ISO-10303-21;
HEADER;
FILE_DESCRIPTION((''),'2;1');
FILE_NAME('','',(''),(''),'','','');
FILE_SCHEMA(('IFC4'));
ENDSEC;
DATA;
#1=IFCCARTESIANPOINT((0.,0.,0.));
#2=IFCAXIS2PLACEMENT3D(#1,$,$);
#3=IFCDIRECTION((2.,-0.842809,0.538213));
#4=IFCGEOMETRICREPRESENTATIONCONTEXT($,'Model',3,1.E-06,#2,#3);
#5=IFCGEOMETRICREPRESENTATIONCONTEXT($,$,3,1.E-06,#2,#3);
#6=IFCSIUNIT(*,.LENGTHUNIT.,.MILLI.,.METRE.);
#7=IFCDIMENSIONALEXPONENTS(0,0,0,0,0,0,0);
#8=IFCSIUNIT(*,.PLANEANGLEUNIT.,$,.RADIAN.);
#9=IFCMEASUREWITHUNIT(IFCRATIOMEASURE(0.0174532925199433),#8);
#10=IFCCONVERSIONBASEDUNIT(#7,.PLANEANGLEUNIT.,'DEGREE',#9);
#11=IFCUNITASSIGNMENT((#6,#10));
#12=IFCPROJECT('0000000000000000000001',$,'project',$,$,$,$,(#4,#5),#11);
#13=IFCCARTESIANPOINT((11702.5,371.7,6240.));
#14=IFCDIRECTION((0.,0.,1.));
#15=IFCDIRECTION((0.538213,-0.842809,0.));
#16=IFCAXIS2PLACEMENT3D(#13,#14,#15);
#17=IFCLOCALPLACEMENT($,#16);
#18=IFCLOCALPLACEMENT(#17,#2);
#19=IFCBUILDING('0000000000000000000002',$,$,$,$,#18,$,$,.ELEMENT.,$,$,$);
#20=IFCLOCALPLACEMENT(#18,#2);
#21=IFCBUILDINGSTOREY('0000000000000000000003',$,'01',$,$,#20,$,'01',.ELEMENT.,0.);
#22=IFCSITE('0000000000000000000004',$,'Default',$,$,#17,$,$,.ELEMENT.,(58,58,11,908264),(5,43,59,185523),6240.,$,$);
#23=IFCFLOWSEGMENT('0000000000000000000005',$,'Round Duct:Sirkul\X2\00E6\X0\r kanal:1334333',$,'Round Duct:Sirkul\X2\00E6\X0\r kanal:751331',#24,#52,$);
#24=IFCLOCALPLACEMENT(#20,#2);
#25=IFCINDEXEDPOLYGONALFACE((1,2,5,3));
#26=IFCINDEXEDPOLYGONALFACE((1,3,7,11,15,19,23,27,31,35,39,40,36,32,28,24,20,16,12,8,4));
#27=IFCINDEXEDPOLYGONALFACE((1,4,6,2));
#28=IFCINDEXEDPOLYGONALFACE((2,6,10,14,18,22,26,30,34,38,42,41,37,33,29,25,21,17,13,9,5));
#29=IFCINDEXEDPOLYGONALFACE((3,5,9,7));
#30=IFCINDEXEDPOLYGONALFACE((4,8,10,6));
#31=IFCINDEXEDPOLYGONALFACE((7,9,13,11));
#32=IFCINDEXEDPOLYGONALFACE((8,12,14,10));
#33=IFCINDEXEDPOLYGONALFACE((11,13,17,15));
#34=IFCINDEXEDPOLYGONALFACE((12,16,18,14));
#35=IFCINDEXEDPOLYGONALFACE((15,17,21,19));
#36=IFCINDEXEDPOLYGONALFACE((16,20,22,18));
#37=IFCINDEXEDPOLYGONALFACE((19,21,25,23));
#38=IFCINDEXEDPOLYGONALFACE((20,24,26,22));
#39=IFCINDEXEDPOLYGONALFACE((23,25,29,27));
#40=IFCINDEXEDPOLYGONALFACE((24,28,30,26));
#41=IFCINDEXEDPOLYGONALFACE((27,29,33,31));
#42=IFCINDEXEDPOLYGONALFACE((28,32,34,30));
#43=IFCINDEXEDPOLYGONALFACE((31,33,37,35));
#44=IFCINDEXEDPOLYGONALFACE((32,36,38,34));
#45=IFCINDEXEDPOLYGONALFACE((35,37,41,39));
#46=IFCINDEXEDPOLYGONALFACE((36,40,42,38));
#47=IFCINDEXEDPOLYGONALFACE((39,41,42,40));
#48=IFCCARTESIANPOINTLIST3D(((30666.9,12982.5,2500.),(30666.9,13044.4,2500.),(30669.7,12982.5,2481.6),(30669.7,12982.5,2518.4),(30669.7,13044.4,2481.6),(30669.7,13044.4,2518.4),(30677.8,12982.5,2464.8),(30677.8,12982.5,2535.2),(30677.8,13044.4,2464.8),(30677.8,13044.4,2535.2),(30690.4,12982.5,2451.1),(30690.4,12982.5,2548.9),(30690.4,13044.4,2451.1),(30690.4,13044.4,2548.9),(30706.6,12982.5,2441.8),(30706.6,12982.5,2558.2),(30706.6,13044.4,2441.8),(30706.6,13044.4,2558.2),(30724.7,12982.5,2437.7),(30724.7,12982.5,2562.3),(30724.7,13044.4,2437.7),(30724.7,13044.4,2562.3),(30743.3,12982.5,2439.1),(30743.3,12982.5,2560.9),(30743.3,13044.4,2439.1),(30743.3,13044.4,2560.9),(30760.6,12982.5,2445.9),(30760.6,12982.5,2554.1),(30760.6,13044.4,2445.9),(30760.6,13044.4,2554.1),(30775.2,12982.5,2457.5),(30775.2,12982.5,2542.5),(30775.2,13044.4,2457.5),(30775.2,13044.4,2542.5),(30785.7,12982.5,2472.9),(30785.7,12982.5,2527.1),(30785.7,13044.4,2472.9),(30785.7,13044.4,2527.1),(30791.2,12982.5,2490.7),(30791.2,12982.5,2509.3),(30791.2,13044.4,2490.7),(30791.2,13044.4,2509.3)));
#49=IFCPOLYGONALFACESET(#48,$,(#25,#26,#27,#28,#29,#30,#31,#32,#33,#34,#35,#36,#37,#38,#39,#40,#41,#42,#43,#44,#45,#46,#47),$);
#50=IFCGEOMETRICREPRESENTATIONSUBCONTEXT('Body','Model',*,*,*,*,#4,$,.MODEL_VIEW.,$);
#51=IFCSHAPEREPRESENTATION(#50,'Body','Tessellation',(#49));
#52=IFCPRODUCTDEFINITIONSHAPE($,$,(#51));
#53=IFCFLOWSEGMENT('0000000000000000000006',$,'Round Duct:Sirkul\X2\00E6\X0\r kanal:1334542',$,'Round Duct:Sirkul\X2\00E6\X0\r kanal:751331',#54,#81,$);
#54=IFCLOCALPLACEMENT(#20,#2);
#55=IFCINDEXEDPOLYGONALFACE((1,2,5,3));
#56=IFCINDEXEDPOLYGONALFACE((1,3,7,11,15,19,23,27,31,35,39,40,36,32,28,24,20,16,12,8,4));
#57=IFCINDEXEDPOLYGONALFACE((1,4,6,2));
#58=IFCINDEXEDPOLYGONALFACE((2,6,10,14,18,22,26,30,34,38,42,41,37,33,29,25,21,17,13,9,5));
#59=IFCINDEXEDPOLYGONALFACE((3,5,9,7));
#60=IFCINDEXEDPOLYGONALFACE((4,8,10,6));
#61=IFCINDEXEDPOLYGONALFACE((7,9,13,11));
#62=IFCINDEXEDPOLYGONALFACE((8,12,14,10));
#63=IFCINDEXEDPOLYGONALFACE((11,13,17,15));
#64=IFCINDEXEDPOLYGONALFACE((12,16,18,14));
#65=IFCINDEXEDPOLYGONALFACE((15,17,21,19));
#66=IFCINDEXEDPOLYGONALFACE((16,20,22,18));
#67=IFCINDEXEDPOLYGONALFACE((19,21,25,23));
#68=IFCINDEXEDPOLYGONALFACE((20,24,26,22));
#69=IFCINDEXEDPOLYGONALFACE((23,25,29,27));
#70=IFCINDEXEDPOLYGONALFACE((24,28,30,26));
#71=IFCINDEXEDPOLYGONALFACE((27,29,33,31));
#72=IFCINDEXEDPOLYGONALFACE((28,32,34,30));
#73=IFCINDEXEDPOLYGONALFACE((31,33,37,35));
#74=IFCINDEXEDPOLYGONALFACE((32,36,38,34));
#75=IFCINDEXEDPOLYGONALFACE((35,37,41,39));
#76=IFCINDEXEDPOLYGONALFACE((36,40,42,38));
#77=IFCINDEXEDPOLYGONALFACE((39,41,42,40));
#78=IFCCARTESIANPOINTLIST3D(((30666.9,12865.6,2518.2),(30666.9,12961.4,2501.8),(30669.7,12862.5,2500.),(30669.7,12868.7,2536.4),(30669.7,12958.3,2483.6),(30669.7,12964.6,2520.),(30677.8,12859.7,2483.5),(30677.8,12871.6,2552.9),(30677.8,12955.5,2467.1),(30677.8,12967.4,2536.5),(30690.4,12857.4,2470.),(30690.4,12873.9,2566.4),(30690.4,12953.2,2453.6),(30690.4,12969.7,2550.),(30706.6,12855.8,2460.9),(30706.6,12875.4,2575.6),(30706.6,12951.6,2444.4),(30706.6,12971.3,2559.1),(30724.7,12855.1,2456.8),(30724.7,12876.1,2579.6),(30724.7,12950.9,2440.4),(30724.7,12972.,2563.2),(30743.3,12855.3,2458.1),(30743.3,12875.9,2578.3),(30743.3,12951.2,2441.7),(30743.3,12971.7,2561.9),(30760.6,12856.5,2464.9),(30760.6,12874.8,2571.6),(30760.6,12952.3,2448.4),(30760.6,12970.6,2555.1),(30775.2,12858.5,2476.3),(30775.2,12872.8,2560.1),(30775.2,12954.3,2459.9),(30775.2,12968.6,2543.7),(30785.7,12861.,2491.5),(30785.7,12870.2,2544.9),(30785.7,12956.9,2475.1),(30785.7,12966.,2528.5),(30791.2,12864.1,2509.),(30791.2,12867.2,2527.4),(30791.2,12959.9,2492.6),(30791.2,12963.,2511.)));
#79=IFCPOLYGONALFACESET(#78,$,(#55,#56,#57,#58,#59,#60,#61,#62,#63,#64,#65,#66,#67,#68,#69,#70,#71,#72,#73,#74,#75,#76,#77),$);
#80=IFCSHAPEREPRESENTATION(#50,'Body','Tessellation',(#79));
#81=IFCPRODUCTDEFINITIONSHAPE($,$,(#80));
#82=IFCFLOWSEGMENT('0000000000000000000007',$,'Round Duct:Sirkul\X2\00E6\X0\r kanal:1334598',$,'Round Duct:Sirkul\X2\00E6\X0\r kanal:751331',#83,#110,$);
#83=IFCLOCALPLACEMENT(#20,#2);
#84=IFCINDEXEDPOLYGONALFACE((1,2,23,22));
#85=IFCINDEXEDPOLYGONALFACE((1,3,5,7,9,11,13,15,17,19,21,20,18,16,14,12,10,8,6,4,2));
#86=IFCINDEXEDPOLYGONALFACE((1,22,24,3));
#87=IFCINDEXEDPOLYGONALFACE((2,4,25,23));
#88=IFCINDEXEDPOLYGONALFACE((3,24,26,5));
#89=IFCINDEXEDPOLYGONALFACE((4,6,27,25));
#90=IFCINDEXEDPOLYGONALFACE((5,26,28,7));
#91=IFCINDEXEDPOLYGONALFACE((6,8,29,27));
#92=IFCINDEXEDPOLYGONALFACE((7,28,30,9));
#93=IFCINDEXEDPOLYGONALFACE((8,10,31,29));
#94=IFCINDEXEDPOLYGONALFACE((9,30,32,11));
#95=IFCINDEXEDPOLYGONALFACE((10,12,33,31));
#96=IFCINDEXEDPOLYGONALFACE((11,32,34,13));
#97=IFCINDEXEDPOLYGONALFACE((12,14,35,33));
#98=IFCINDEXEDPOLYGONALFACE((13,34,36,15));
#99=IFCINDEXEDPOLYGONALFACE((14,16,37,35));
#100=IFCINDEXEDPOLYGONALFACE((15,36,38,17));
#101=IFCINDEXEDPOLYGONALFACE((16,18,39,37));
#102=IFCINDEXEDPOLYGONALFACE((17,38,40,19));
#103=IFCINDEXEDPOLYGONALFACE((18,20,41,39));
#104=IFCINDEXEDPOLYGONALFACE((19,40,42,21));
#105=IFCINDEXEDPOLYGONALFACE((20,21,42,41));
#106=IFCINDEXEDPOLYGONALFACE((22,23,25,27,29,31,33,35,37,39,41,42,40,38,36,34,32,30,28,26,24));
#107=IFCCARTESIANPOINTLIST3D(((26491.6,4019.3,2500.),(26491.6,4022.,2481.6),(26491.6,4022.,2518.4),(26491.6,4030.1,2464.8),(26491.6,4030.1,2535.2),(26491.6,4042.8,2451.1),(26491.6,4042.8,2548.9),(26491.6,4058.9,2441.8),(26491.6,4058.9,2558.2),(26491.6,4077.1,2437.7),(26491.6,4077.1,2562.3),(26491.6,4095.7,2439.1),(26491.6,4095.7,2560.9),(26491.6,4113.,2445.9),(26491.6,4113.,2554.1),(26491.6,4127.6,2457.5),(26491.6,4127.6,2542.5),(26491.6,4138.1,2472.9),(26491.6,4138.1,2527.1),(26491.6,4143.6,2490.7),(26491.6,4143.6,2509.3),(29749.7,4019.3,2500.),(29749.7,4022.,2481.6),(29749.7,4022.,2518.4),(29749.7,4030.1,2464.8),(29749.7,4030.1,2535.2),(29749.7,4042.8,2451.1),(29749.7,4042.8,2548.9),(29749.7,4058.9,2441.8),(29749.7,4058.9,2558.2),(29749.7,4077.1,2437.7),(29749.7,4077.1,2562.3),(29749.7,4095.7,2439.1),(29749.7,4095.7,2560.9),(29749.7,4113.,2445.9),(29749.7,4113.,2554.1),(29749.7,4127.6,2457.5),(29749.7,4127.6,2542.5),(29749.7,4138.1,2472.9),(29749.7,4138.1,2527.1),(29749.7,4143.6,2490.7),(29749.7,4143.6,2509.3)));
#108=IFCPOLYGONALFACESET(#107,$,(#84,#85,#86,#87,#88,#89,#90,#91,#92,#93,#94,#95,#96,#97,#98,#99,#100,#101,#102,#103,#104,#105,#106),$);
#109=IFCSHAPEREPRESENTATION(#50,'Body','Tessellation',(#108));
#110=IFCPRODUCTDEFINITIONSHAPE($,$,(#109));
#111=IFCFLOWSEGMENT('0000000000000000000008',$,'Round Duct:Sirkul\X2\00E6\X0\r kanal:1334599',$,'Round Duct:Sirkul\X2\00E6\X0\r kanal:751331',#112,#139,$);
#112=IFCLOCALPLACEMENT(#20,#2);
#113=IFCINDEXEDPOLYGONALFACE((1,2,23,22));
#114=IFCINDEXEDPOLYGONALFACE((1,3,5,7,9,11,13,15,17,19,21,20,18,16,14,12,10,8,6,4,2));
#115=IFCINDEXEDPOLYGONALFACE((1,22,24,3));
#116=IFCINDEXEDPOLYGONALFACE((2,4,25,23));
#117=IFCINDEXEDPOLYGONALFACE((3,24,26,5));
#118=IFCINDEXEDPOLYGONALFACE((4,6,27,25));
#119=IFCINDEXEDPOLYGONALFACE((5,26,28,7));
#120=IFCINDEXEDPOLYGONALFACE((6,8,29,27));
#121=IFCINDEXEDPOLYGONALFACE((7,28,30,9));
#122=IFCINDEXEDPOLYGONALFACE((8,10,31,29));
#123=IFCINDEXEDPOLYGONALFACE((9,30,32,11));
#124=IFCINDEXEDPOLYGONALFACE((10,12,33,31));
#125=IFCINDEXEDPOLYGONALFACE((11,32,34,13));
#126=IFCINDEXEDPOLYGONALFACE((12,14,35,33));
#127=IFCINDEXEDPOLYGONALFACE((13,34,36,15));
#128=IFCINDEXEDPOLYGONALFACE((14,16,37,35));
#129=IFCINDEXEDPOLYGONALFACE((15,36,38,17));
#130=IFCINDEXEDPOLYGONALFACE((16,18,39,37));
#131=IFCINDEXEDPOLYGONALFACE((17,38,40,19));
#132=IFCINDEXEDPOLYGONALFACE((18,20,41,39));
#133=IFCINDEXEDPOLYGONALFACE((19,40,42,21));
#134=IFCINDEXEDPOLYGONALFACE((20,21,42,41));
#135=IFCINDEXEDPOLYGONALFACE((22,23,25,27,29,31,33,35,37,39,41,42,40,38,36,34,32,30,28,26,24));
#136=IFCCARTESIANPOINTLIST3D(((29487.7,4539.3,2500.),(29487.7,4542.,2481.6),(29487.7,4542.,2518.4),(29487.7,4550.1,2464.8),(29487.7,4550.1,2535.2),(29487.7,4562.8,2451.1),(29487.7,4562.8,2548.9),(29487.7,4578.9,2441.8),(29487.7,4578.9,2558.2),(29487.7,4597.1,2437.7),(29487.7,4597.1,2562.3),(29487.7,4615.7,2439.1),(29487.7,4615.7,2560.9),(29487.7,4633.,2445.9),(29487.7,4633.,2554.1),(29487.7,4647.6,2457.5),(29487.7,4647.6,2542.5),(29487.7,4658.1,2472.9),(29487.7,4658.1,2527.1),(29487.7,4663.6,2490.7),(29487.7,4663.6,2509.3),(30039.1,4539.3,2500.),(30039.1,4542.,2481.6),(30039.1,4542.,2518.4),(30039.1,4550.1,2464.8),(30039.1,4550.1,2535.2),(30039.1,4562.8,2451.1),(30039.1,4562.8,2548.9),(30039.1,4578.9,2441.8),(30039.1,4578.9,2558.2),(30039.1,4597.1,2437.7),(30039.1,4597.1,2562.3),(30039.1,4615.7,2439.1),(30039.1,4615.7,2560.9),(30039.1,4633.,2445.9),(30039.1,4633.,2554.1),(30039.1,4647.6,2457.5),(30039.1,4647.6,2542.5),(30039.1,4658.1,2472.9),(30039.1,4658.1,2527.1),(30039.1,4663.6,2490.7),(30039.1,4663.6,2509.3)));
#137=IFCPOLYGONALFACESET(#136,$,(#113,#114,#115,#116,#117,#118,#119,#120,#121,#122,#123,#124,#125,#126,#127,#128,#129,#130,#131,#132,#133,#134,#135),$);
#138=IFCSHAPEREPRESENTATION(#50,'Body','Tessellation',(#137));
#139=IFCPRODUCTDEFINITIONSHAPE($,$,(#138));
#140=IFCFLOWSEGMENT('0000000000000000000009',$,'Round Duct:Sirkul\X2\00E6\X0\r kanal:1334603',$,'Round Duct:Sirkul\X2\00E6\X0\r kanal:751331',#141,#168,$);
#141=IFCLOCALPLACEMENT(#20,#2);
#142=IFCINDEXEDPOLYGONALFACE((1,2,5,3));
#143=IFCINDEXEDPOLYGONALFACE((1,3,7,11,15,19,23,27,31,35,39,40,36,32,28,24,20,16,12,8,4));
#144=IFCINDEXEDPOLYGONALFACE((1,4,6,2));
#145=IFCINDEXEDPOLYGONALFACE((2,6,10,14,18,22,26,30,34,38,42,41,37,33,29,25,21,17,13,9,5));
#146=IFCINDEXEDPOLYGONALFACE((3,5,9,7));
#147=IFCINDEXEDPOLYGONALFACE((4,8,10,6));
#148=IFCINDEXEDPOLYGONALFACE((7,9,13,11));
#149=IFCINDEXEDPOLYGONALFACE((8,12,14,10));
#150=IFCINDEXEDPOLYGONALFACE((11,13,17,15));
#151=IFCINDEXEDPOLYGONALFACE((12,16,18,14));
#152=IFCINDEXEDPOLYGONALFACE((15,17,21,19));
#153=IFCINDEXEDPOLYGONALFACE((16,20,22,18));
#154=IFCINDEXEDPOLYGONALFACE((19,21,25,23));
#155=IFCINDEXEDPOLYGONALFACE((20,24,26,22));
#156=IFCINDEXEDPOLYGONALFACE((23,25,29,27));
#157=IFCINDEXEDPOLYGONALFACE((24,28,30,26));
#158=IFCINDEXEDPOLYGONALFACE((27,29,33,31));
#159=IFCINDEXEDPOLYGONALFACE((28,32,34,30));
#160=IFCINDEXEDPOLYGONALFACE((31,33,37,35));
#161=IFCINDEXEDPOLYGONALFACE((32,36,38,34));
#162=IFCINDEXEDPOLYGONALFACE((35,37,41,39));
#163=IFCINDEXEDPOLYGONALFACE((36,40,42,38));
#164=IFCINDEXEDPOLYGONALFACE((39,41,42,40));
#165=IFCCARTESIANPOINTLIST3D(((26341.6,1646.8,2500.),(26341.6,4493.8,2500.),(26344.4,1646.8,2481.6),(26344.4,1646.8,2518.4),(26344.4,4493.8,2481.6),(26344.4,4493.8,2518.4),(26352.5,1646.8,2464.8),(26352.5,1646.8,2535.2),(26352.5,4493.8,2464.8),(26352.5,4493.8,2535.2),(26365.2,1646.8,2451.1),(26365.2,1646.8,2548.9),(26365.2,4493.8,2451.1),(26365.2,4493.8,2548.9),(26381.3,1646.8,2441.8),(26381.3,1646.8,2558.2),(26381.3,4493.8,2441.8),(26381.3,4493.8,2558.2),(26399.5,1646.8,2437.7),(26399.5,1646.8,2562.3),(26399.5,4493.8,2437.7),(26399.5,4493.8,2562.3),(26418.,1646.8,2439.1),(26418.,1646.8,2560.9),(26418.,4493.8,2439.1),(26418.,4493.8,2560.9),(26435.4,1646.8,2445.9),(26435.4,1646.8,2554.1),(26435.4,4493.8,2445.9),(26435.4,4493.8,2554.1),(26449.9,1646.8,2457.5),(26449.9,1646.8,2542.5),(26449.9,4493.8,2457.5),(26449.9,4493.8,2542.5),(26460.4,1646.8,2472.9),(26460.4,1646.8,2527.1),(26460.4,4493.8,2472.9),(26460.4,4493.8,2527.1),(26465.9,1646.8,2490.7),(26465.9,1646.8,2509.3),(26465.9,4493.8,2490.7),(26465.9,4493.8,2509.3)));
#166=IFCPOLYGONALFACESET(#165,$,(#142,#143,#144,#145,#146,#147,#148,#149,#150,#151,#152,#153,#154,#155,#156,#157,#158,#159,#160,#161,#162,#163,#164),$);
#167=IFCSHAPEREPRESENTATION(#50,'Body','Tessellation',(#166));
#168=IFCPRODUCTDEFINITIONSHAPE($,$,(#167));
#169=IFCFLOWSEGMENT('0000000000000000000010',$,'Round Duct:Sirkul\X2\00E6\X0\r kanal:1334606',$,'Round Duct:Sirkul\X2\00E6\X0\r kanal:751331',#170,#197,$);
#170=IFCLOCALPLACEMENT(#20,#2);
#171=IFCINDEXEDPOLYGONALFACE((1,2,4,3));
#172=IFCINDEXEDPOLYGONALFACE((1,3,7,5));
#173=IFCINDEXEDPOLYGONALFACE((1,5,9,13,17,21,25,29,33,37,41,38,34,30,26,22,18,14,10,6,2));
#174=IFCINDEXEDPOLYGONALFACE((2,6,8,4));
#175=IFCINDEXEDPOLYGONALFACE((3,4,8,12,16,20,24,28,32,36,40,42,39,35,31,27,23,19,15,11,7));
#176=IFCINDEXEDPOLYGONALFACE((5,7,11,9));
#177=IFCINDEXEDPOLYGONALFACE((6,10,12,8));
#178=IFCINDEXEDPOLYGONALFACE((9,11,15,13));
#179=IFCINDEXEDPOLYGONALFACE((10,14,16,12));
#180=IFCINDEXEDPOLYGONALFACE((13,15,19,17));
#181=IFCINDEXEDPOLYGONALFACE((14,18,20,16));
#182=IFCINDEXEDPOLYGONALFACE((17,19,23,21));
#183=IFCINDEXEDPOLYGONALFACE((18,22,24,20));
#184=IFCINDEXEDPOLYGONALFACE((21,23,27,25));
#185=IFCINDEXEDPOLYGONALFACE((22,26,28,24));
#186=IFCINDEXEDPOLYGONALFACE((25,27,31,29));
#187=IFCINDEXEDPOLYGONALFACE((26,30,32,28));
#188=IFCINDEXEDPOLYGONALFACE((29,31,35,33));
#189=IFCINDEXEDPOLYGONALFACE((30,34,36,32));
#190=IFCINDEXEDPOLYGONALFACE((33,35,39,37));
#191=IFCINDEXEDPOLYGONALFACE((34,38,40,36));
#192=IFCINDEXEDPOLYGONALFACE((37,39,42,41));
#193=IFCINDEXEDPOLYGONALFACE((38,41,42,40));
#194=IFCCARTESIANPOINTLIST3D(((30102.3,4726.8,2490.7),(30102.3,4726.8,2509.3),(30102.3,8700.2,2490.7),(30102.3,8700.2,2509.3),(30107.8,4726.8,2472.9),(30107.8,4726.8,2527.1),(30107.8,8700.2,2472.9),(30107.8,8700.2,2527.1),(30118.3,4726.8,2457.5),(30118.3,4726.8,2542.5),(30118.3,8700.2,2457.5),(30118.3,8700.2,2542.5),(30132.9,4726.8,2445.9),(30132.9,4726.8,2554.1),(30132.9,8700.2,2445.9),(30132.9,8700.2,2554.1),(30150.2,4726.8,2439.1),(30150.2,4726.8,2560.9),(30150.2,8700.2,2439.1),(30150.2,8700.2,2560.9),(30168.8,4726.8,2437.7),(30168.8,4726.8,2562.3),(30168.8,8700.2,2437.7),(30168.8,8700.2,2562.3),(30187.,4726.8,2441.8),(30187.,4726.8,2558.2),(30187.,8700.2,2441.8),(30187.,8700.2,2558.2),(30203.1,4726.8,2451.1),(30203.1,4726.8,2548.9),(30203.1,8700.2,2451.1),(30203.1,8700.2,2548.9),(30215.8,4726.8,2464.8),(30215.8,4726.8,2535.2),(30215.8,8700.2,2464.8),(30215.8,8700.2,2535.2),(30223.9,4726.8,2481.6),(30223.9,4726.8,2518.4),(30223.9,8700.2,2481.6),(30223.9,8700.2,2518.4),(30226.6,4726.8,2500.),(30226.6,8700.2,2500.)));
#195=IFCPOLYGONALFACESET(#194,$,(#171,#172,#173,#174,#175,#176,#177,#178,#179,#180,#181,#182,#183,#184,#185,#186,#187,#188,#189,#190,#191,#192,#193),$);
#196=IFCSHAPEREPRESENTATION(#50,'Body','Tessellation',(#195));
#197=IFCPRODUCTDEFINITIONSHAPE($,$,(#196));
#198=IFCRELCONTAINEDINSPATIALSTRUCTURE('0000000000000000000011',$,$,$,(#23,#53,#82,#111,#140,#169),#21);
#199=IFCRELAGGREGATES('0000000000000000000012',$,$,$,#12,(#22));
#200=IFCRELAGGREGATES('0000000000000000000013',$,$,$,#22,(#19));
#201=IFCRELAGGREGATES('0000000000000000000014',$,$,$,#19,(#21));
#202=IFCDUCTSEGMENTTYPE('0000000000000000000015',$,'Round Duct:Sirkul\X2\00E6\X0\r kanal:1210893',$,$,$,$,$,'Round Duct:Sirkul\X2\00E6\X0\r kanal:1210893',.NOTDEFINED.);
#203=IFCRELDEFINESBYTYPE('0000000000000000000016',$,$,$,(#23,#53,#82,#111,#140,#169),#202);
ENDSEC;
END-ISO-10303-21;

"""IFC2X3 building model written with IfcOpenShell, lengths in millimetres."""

from ifc_helpers import new_model, entity, si_unit, converted_unit, direction, frame, frame_2d, origin, origin_2d_with_axis, place, context, subcontext, project, spatial, circle, extrude, type_object, element, save


model = new_model("IFC2X3")

# Units and contexts
model_context = context("Model", 3, precision=1e-06, world=origin(), true_north=direction((2.0, -0.842809, 0.538213)))
context_of_model = context(None, 3, precision=1e-06, world=origin(), true_north=direction((2.0, -0.842809, 0.538213)))
body_context = subcontext(model_context, "Body", "Model", "MODEL_VIEW")
ifc_project = project(units=[si_unit("LENGTHUNIT", "METRE", prefix="MILLI"), converted_unit("PLANEANGLEUNIT", "DEGREE", entity("IfcRatioMeasure", 0.0174532925199433), si_unit("PLANEANGLEUNIT", "RADIAN"), dimensions=[0, 0, 0, 0, 0, 0, 0])], contexts=[model_context, context_of_model])

# Site, building, storey
site_placement = place(None, frame((11702.5, 371.7, 6240.0), z_axis=(0.0, 0.0, 1.0), x_axis=(0.538213, -0.842809, 0.0)))
site = spatial("IfcSite", under=ifc_project, at=site_placement, Name="Default", CompositionType="ELEMENT", RefLatitude=(58, 58, 11, 908264), RefLongitude=(5, 43, 59, 185523), RefElevation=6240.0)
building_placement = place(site_placement, origin())
building = spatial("IfcBuilding", under=site, at=building_placement, CompositionType="ELEMENT")
storey_placement = place(building_placement, origin())
storey = spatial("IfcBuildingStorey", under=building, at=storey_placement, Name="01", LongName="01", CompositionType="ELEMENT", Elevation=0.0)

# Flow segments
duct_segment_type = type_object("IfcDuctSegmentType", Name="Round Duct:Sirkulær kanal:1210893", ElementType="Round Duct:Sirkulær kanal:1210893", PredefinedType="NOTDEFINED")
flow_segment_1_placement = place(storey_placement, origin())
element("IfcFlowSegment", 1, at=flow_segment_1_placement, inside=storey, type_object=duct_segment_type, Name="Round Duct:Sirkulær kanal:1334333", ObjectType="Round Duct:Sirkulær kanal:751331", context=body_context, shape_type="SweptSolid", body=[
    extrude(circle(Radius=62.5, at=frame_2d((0.0, 0.0), x_axis=(1.0, 0.0))), frame((30729.4, 12982.5, 2500.0), z_axis=(0.0, 1.0, 0.0), x_axis=(-1.0, 0.0, 0.0)), (0.0, 0.0, 1.0), 61.9),
])
flow_segment_2_placement = place(storey_placement, origin())
element("IfcFlowSegment", 2, at=flow_segment_2_placement, inside=storey, type_object=duct_segment_type, Name="Round Duct:Sirkulær kanal:1334542", ObjectType="Round Duct:Sirkulær kanal:751331", context=body_context, shape_type="SweptSolid", body=[
    extrude(circle(Radius=62.5, at=frame_2d((0.0, 0.0), x_axis=(1.0, 0.0))), frame((30729.4, 12961.4, 2501.8), z_axis=(0.0, -0.985646, 0.168824), x_axis=(-1.0, 0.0, 0.0)), (0.0, 0.0, 1.0), 97.2),
])
flow_segment_3_placement = place(storey_placement, origin())
element("IfcFlowSegment", 3, at=flow_segment_3_placement, inside=storey, type_object=duct_segment_type, Name="Round Duct:Sirkulær kanal:1334598", ObjectType="Round Duct:Sirkulær kanal:751331", context=body_context, shape_type="SweptSolid", body=[
    extrude(circle(Radius=62.5, at=origin_2d_with_axis()), frame((26491.6, 4081.8, 2500.0), z_axis=(1.0, 0.0, 0.0), x_axis=(0.0, -1.0, 0.0)), (0.0, 0.0, 1.0), 3258.0),
])
flow_segment_4_placement = place(storey_placement, origin())
element("IfcFlowSegment", 4, at=flow_segment_4_placement, inside=storey, type_object=duct_segment_type, Name="Round Duct:Sirkulær kanal:1334599", ObjectType="Round Duct:Sirkulær kanal:751331", context=body_context, shape_type="SweptSolid", body=[
    extrude(circle(Radius=62.5, at=origin_2d_with_axis()), frame((29487.7, 4601.8, 2500.0), z_axis=(1.0, 0.0, 0.0), x_axis=(0.0, -1.0, 0.0)), (0.0, 0.0, 1.0), 551.4),
])
flow_segment_5_placement = place(storey_placement, origin())
element("IfcFlowSegment", 5, at=flow_segment_5_placement, inside=storey, type_object=duct_segment_type, Name="Round Duct:Sirkulær kanal:1334603", ObjectType="Round Duct:Sirkulær kanal:751331", context=body_context, shape_type="SweptSolid", body=[
    extrude(circle(Radius=62.5, at=origin_2d_with_axis()), frame((26404.1, 1646.8, 2500.0), z_axis=(0.0, 1.0, 0.0), x_axis=(-1.0, 0.0, 0.0)), (0.0, 0.0, 1.0), 2847.0),
])
flow_segment_6_placement = place(storey_placement, origin())
element("IfcFlowSegment", 6, at=flow_segment_6_placement, inside=storey, type_object=duct_segment_type, Name="Round Duct:Sirkulær kanal:1334606", ObjectType="Round Duct:Sirkulær kanal:751331", context=body_context, shape_type="SweptSolid", body=[
    extrude(circle(Radius=62.5, at=origin_2d_with_axis()), frame((30164.1, 4726.8, 2500.0), z_axis=(0.0, 1.0, 0.0), x_axis=(1.0, 0.0, 0.0)), (0.0, 0.0, 1.0), 3973.5),
])

save(model, "model.ifc")
